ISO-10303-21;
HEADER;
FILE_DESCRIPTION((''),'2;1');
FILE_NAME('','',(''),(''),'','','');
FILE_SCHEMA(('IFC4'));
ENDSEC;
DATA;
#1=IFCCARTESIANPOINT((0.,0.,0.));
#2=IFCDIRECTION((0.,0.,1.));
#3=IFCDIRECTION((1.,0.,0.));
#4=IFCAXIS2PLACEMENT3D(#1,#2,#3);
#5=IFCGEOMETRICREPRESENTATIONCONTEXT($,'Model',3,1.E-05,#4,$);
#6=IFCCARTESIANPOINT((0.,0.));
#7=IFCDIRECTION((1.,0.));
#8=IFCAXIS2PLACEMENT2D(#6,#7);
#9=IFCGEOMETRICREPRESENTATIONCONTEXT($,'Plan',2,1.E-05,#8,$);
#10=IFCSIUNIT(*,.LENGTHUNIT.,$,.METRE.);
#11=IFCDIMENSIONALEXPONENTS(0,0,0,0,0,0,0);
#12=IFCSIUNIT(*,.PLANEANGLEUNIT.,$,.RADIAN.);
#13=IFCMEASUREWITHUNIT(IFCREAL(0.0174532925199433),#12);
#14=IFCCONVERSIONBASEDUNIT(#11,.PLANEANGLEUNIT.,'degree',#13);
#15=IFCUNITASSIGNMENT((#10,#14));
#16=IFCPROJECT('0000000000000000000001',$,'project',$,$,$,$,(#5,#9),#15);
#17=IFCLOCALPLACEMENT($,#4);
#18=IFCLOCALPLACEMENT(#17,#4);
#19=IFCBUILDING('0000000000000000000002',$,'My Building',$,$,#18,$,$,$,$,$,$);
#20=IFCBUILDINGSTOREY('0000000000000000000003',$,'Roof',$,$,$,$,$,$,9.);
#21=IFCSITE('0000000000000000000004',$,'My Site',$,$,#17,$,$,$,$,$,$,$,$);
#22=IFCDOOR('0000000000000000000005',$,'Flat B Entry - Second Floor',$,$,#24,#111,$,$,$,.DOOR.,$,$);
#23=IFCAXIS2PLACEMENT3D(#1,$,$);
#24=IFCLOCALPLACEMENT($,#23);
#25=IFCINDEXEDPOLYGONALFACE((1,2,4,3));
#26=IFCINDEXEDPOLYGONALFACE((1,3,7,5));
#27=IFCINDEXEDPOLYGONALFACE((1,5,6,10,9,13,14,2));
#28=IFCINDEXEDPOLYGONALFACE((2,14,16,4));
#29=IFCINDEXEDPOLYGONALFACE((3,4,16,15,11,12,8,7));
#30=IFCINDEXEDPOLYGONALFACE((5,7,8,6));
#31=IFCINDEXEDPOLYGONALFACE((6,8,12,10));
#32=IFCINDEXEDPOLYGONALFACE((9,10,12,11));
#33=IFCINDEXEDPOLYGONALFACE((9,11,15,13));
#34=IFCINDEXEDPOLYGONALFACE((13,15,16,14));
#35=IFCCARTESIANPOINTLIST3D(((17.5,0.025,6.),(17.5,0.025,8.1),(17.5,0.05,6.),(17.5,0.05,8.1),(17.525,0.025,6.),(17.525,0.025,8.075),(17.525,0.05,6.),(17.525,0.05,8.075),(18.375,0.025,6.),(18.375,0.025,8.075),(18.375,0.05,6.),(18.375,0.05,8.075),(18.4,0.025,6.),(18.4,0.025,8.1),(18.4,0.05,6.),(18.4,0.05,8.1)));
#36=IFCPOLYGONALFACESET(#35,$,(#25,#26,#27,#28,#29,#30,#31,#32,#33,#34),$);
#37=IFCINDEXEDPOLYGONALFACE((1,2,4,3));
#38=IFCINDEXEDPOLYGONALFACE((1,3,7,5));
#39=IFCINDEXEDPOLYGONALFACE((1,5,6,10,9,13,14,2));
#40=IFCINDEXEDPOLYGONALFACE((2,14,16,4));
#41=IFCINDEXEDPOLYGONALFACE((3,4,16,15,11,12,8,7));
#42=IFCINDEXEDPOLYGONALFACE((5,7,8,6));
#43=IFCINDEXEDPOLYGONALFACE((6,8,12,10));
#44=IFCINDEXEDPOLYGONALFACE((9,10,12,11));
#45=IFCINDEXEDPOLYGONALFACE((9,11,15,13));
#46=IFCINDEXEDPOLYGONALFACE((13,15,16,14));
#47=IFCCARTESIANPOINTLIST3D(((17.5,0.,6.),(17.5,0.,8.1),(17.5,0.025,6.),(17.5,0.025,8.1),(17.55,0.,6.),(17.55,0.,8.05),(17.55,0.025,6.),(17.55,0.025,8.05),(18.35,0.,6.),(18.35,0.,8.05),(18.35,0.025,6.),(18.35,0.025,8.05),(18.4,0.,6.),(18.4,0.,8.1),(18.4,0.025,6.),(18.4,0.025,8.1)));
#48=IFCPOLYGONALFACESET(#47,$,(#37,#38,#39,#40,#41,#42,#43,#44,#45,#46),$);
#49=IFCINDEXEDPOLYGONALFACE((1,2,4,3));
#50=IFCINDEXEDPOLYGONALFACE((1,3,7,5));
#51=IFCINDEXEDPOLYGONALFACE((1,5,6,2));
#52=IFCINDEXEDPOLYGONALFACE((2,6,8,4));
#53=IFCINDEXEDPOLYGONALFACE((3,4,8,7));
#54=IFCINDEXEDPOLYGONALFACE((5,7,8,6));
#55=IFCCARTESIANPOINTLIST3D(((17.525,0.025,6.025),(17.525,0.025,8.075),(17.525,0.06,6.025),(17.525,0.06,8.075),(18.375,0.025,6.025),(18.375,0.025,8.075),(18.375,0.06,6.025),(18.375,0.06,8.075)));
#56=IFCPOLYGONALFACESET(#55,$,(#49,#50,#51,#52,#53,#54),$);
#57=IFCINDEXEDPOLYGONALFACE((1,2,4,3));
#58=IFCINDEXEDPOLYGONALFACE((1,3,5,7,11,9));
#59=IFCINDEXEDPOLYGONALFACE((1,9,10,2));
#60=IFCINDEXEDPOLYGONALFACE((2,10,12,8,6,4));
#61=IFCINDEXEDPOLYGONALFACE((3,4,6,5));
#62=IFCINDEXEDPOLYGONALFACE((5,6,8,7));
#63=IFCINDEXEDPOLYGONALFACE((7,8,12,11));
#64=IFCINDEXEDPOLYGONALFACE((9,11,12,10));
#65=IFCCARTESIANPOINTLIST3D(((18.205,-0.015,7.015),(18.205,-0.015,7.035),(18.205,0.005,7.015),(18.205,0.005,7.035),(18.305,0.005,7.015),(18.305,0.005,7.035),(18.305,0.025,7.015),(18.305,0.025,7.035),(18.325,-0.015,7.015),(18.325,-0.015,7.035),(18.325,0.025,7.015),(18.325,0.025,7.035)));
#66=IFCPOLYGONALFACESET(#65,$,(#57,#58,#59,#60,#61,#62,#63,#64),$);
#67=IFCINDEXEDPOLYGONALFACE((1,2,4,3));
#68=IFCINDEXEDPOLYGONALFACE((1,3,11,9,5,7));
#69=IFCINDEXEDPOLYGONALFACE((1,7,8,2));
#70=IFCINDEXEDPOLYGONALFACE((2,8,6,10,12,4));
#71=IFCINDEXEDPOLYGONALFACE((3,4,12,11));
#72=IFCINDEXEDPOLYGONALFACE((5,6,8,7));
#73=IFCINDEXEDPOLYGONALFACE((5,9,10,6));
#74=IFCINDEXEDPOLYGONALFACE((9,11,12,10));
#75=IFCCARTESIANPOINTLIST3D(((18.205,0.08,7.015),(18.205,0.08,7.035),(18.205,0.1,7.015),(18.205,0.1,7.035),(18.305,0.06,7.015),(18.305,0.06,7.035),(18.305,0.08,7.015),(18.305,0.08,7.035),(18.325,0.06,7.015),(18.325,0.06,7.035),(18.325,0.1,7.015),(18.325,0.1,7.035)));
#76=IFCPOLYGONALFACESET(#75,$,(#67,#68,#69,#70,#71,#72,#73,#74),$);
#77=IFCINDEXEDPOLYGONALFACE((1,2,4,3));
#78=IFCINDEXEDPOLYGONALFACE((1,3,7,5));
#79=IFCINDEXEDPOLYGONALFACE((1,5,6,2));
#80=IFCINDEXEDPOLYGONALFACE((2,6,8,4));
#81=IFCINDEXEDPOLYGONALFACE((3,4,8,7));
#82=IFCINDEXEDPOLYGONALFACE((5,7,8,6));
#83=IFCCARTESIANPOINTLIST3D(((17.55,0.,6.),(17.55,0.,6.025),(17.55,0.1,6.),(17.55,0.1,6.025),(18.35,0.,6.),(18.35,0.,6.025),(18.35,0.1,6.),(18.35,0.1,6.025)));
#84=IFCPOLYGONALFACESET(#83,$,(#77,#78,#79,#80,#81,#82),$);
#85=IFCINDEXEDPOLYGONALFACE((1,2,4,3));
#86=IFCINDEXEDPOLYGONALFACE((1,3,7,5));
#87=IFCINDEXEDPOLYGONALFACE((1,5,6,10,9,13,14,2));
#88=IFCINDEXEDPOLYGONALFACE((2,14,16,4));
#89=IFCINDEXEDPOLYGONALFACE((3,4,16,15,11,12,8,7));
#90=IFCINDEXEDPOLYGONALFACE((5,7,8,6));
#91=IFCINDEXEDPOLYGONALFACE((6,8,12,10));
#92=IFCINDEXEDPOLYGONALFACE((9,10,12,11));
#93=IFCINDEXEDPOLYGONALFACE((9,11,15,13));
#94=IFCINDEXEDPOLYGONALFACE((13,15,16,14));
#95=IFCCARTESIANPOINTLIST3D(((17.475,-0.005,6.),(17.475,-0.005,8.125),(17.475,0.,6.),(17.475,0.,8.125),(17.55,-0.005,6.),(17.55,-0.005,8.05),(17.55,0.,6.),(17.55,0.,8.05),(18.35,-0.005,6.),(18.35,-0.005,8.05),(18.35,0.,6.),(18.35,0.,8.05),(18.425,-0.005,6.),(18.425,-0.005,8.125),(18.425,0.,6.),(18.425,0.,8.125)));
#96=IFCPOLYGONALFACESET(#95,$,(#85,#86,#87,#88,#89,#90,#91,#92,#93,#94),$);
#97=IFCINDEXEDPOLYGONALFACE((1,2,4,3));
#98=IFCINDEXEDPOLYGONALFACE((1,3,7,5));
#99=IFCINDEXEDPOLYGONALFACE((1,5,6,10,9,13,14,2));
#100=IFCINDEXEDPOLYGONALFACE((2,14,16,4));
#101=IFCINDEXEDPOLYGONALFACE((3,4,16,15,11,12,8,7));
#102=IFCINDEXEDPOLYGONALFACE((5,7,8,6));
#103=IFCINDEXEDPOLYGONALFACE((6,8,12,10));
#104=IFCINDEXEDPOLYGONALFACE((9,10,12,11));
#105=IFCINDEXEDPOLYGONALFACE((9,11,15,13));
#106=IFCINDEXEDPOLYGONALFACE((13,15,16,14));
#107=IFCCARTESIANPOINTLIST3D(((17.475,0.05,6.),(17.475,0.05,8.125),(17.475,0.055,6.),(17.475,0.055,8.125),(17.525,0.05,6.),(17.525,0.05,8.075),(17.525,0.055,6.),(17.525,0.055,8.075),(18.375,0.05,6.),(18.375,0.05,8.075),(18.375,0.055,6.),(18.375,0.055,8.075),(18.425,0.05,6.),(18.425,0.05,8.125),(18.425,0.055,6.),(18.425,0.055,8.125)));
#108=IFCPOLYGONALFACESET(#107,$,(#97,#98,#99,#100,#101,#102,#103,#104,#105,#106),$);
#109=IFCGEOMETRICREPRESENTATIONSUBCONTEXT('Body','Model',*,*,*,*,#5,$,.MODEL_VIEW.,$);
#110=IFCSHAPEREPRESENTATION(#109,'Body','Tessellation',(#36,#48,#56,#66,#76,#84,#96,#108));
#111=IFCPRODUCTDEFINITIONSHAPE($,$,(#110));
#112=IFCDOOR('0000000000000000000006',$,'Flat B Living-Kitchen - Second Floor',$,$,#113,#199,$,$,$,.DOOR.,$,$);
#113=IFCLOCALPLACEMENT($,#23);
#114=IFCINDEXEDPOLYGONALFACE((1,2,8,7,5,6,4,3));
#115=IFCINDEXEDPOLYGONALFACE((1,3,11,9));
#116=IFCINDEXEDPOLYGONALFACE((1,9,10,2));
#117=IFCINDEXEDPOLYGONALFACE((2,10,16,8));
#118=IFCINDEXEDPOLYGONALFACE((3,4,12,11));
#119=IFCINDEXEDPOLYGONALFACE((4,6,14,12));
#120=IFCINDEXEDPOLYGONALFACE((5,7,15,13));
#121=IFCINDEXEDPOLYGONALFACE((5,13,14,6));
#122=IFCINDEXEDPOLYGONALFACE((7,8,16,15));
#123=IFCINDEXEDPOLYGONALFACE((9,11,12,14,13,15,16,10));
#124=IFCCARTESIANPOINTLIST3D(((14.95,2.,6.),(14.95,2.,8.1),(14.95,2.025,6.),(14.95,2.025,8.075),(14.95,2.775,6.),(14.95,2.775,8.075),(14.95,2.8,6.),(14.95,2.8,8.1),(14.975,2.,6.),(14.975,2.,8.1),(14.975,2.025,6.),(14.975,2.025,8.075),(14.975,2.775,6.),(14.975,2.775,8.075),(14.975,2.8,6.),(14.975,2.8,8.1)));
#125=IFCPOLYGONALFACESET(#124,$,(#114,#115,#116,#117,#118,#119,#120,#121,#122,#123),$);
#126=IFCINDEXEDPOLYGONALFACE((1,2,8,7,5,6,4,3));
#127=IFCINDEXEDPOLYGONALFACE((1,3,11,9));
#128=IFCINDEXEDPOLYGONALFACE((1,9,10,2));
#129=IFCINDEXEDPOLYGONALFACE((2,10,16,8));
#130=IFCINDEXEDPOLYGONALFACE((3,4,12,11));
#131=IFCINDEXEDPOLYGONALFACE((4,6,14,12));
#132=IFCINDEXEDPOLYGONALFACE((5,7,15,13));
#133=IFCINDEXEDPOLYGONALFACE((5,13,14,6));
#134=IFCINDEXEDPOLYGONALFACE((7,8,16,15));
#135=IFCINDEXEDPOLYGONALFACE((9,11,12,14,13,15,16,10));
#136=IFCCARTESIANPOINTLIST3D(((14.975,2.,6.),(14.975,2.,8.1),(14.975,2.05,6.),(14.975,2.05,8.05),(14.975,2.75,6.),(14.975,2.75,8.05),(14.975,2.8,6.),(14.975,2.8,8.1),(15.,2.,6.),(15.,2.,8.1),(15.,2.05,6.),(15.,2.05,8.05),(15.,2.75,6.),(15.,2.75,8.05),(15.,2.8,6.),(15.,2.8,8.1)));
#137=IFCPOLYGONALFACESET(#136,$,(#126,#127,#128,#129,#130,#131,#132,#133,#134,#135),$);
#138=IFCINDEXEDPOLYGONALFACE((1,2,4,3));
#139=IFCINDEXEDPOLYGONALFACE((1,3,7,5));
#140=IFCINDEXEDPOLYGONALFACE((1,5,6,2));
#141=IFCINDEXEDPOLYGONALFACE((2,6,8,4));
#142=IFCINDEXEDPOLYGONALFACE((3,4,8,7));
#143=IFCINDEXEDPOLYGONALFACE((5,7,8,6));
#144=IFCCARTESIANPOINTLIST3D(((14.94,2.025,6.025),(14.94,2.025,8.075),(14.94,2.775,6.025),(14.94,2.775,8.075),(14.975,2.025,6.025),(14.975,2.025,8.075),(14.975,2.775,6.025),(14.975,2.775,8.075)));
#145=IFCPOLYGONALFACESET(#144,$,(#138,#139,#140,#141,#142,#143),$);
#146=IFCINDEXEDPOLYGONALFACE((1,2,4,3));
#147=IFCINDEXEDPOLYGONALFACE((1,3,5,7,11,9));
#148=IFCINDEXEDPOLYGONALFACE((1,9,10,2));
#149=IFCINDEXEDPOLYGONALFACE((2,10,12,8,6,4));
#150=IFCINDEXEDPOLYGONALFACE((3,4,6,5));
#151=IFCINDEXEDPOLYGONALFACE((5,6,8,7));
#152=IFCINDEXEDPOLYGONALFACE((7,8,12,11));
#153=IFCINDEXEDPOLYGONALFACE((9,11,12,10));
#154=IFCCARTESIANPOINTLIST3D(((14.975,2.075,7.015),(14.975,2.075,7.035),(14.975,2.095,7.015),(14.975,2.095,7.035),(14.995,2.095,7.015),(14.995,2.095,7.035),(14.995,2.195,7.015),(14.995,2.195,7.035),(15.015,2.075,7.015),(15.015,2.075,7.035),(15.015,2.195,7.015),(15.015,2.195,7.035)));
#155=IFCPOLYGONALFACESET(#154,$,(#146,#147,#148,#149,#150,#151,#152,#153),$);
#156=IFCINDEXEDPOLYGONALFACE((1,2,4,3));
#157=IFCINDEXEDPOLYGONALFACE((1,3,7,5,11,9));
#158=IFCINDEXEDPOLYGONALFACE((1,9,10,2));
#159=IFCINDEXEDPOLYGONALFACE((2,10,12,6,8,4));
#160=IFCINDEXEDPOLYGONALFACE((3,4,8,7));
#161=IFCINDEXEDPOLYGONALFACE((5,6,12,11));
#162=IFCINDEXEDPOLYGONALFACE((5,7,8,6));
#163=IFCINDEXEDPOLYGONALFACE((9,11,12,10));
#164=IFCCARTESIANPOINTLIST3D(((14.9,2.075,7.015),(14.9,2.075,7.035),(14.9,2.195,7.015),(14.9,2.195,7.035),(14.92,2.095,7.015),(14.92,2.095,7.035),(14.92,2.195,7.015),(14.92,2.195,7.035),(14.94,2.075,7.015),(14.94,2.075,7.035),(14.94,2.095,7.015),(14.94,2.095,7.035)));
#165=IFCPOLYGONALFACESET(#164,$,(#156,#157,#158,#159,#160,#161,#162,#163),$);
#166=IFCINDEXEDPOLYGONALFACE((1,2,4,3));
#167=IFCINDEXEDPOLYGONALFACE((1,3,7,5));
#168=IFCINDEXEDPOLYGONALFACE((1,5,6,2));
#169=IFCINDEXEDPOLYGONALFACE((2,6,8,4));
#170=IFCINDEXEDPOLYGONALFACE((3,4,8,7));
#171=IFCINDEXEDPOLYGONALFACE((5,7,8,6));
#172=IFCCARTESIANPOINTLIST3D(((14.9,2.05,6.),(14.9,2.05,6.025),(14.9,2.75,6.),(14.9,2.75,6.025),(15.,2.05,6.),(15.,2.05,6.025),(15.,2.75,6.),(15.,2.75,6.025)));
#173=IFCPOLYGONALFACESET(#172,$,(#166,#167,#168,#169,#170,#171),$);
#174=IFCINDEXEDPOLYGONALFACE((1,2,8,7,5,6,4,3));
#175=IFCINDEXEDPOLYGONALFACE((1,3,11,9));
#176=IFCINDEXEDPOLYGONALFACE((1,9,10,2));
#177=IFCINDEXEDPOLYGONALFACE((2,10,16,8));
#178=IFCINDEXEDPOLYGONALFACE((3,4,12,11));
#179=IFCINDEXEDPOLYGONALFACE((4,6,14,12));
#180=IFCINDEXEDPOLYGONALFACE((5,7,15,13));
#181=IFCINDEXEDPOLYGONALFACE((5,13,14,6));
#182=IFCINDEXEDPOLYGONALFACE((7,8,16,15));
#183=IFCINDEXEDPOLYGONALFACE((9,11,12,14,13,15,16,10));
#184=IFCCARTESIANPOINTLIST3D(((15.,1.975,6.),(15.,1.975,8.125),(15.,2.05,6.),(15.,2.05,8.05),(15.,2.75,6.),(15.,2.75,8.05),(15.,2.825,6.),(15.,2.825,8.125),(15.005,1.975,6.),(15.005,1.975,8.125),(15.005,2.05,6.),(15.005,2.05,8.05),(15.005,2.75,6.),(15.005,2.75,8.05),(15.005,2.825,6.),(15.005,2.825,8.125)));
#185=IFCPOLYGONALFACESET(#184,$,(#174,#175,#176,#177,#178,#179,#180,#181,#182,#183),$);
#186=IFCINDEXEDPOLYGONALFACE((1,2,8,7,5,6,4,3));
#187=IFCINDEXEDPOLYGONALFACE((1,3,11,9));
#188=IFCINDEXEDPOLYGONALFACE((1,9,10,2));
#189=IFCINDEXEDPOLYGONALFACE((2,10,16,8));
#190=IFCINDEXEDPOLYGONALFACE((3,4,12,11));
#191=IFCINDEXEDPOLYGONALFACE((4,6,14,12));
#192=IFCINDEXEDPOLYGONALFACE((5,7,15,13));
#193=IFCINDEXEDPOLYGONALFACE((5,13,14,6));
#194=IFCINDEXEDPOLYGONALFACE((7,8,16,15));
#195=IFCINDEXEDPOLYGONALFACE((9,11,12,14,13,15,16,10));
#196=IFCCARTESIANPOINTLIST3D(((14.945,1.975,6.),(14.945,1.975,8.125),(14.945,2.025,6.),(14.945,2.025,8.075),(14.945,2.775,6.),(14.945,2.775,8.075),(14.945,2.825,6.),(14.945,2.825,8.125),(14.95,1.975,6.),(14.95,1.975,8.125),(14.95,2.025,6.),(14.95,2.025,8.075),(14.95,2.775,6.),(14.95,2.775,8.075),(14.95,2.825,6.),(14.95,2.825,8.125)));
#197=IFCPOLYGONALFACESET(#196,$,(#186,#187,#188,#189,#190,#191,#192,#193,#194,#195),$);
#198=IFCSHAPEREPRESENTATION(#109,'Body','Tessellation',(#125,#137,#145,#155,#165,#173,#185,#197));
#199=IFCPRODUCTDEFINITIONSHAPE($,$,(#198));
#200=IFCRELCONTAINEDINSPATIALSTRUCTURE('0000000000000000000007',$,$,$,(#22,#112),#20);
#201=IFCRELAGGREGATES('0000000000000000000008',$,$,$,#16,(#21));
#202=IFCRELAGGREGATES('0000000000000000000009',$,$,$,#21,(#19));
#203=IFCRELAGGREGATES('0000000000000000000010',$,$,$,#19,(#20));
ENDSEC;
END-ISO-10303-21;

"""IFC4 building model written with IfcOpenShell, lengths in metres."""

from ifc_helpers import new_model, entity, si_unit, converted_unit, frame, origin_with_axes, origin_2d_with_axis, place, context, subcontext, project, spatial, line, indexed_curve, outline, extrude, element, save


model = new_model("IFC4")

# Units and contexts
model_context = context("Model", 3, precision=1e-05, world=origin_with_axes())
plan_context = context("Plan", 2, precision=1e-05, world=origin_2d_with_axis())
body_context = subcontext(model_context, "Body", "Model", "MODEL_VIEW")
ifc_project = project(units=[si_unit("LENGTHUNIT", "METRE"), converted_unit("PLANEANGLEUNIT", "degree", entity("IfcReal", 0.0174532925199433), si_unit("PLANEANGLEUNIT", "RADIAN"), dimensions=[0, 0, 0, 0, 0, 0, 0])], contexts=[model_context, plan_context])

# Site, building, storey
site_placement = place(None, origin_with_axes())
site = spatial("IfcSite", under=ifc_project, at=site_placement, Name="My Site")
building_placement = place(site_placement, origin_with_axes())
building = spatial("IfcBuilding", under=site, at=building_placement, Name="My Building")
storey = spatial("IfcBuildingStorey", under=building, Name="Roof", Elevation=9.0)

# Doors
door_1_placement = place(None, frame((17.5, 0.0, 6.0), z_axis=(0.0, 0.0, 1.0), x_axis=(1.0, 0.0, 0.0)))
element("IfcDoor", 1, at=door_1_placement, inside=storey, Name="Flat B Entry - Second Floor", PredefinedType="DOOR", context=body_context, shape_type="SweptSolid", body=[
    extrude(outline(indexed_curve([(0.0, 0.0), (0.0, 2.1), (0.9, 2.1), (0.9, 0.0), (0.875, 0.0), (0.875, 2.075), (0.025, 2.075), (0.025, 0.0)], segments=[line(1, 2, 3, 4, 5, 6, 7, 8, 1)])), frame((0.0, 0.025, 0.0), z_axis=(0.0, -1.0, 0.0), x_axis=(1.0, 0.0, 0.0)), (0.0, 0.0, -1.0), 0.025),
    extrude(outline(indexed_curve([(0.0, 0.0), (0.0, 2.1), (0.9, 2.1), (0.9, 0.0), (0.85, 0.0), (0.85, 2.05), (0.05, 2.05), (0.05, 0.0)], segments=[line(1, 2, 3, 4, 5, 6, 7, 8, 1)])), frame((0.0, 0.0, 0.0), z_axis=(0.0, -1.0, 0.0), x_axis=(1.0, 0.0, 0.0)), (0.0, 0.0, -1.0), 0.025),
    extrude(outline(indexed_curve([(0.0, 0.0), (0.85, 0.0), (0.85, 0.035), (0.0, 0.035)], segments=[line(1, 2, 3, 4, 1)])), frame((0.025, 0.025, 0.025), z_axis=(0.0, 0.0, 1.0), x_axis=(1.0, 0.0, 0.0)), (0.0, 0.0, 1.0), 2.05),
    extrude(outline(indexed_curve([(0.0, 0.0), (0.0, -0.04), (-0.12, -0.04), (-0.12, -0.02), (-0.02, -0.02), (-0.02, 0.0)], segments=[line(1, 2, 3, 4, 5, 6, 1)])), frame((0.825, 0.025, 1.015), z_axis=(0.0, 0.0, 1.0), x_axis=(1.0, 0.0, 0.0)), (0.0, 0.0, 1.0), 0.02),
    extrude(outline(indexed_curve([(0.0, 0.0), (0.0, 0.04), (-0.12, 0.04), (-0.12, 0.02), (-0.02, 0.02), (-0.02, 0.0)], segments=[line(1, 2, 3, 4, 5, 6, 1)])), frame((0.825, 0.06, 1.015), z_axis=(0.0, 0.0, 1.0), x_axis=(1.0, 0.0, 0.0)), (0.0, 0.0, 1.0), 0.02),
    extrude(outline(indexed_curve([(0.0, 0.0), (0.8, 0.0), (0.8, 0.1), (0.0, 0.1)], segments=[line(1, 2, 3, 4, 1)])), frame((0.05, 0.0, 0.0), z_axis=(0.0, 0.0, 1.0), x_axis=(1.0, 0.0, 0.0)), (0.0, 0.0, 1.0), 0.025),
    extrude(outline(indexed_curve([(0.0, 0.0), (0.0, 2.125), (0.95, 2.125), (0.95, 0.0), (0.875, 0.0), (0.875, 2.05), (0.075, 2.05), (0.075, 0.0)], segments=[line(1, 2, 3, 4, 5, 6, 7, 8, 1)])), frame((-0.025, -0.005, 0.0), z_axis=(0.0, -1.0, 0.0), x_axis=(1.0, 0.0, 0.0)), (0.0, 0.0, -1.0), 0.005),
    extrude(outline(indexed_curve([(0.0, 0.0), (0.0, 2.125), (0.95, 2.125), (0.95, 0.0), (0.9, 0.0), (0.9, 2.075), (0.05, 2.075), (0.05, 0.0)], segments=[line(1, 2, 3, 4, 5, 6, 7, 8, 1)])), frame((-0.025, 0.05, 0.0), z_axis=(0.0, -1.0, 0.0), x_axis=(1.0, 0.0, 0.0)), (0.0, 0.0, -1.0), 0.005),
])
door_2_placement = place(None, frame((15.0, 2.0, 6.0), z_axis=(0.0, 0.0, 1.0), x_axis=(0.0, 1.0, 0.0)))
element("IfcDoor", 2, at=door_2_placement, inside=storey, Name="Flat B Living-Kitchen - Second Floor", PredefinedType="DOOR", context=body_context, shape_type="SweptSolid", body=[
    extrude(outline(indexed_curve([(0.0, 0.0), (0.0, 2.1), (0.8, 2.1), (0.8, 0.0), (0.775, 0.0), (0.775, 2.075), (0.025, 2.075), (0.025, 0.0)], segments=[line(1, 2, 3, 4, 5, 6, 7, 8, 1)])), frame((0.0, 0.025, 0.0), z_axis=(0.0, -1.0, 0.0), x_axis=(1.0, 0.0, 0.0)), (0.0, 0.0, -1.0), 0.025),
    extrude(outline(indexed_curve([(0.0, 0.0), (0.0, 2.1), (0.8, 2.1), (0.8, 0.0), (0.75, 0.0), (0.75, 2.05), (0.05, 2.05), (0.05, 0.0)], segments=[line(1, 2, 3, 4, 5, 6, 7, 8, 1)])), frame((0.0, 0.0, 0.0), z_axis=(0.0, -1.0, 0.0), x_axis=(1.0, 0.0, 0.0)), (0.0, 0.0, -1.0), 0.025),
    extrude(outline(indexed_curve([(0.0, 0.0), (0.75, 0.0), (0.75, 0.035), (0.0, 0.035)], segments=[line(1, 2, 3, 4, 1)])), frame((0.025, 0.025, 0.025), z_axis=(0.0, 0.0, 1.0), x_axis=(1.0, 0.0, 0.0)), (0.0, 0.0, 1.0), 2.05),
    extrude(outline(indexed_curve([(0.0, 0.0), (0.0, -0.04), (0.12, -0.04), (0.12, -0.02), (0.02, -0.02), (0.02, 0.0)], segments=[line(1, 2, 3, 4, 5, 6, 1)])), frame((0.075, 0.025, 1.015), z_axis=(0.0, 0.0, 1.0), x_axis=(1.0, 0.0, 0.0)), (0.0, 0.0, 1.0), 0.02),
    extrude(outline(indexed_curve([(0.0, 0.0), (0.0, 0.04), (0.12, 0.04), (0.12, 0.02), (0.02, 0.02), (0.02, 0.0)], segments=[line(1, 2, 3, 4, 5, 6, 1)])), frame((0.075, 0.06, 1.015), z_axis=(0.0, 0.0, 1.0), x_axis=(1.0, 0.0, 0.0)), (0.0, 0.0, 1.0), 0.02),
    extrude(outline(indexed_curve([(0.0, 0.0), (0.7, 0.0), (0.7, 0.1), (0.0, 0.1)], segments=[line(1, 2, 3, 4, 1)])), frame((0.05, 0.0, 0.0), z_axis=(0.0, 0.0, 1.0), x_axis=(1.0, 0.0, 0.0)), (0.0, 0.0, 1.0), 0.025),
    extrude(outline(indexed_curve([(0.0, 0.0), (0.0, 2.125), (0.85, 2.125), (0.85, 0.0), (0.775, 0.0), (0.775, 2.05), (0.075, 2.05), (0.075, 0.0)], segments=[line(1, 2, 3, 4, 5, 6, 7, 8, 1)])), frame((-0.025, -0.005, 0.0), z_axis=(0.0, -1.0, 0.0), x_axis=(1.0, 0.0, 0.0)), (0.0, 0.0, -1.0), 0.005),
    extrude(outline(indexed_curve([(0.0, 0.0), (0.0, 2.125), (0.85, 2.125), (0.85, 0.0), (0.8, 0.0), (0.8, 2.075), (0.05, 2.075), (0.05, 0.0)], segments=[line(1, 2, 3, 4, 5, 6, 7, 8, 1)])), frame((-0.025, 0.05, 0.0), z_axis=(0.0, -1.0, 0.0), x_axis=(1.0, 0.0, 0.0)), (0.0, 0.0, -1.0), 0.005),
])

save(model, "model.ifc")
